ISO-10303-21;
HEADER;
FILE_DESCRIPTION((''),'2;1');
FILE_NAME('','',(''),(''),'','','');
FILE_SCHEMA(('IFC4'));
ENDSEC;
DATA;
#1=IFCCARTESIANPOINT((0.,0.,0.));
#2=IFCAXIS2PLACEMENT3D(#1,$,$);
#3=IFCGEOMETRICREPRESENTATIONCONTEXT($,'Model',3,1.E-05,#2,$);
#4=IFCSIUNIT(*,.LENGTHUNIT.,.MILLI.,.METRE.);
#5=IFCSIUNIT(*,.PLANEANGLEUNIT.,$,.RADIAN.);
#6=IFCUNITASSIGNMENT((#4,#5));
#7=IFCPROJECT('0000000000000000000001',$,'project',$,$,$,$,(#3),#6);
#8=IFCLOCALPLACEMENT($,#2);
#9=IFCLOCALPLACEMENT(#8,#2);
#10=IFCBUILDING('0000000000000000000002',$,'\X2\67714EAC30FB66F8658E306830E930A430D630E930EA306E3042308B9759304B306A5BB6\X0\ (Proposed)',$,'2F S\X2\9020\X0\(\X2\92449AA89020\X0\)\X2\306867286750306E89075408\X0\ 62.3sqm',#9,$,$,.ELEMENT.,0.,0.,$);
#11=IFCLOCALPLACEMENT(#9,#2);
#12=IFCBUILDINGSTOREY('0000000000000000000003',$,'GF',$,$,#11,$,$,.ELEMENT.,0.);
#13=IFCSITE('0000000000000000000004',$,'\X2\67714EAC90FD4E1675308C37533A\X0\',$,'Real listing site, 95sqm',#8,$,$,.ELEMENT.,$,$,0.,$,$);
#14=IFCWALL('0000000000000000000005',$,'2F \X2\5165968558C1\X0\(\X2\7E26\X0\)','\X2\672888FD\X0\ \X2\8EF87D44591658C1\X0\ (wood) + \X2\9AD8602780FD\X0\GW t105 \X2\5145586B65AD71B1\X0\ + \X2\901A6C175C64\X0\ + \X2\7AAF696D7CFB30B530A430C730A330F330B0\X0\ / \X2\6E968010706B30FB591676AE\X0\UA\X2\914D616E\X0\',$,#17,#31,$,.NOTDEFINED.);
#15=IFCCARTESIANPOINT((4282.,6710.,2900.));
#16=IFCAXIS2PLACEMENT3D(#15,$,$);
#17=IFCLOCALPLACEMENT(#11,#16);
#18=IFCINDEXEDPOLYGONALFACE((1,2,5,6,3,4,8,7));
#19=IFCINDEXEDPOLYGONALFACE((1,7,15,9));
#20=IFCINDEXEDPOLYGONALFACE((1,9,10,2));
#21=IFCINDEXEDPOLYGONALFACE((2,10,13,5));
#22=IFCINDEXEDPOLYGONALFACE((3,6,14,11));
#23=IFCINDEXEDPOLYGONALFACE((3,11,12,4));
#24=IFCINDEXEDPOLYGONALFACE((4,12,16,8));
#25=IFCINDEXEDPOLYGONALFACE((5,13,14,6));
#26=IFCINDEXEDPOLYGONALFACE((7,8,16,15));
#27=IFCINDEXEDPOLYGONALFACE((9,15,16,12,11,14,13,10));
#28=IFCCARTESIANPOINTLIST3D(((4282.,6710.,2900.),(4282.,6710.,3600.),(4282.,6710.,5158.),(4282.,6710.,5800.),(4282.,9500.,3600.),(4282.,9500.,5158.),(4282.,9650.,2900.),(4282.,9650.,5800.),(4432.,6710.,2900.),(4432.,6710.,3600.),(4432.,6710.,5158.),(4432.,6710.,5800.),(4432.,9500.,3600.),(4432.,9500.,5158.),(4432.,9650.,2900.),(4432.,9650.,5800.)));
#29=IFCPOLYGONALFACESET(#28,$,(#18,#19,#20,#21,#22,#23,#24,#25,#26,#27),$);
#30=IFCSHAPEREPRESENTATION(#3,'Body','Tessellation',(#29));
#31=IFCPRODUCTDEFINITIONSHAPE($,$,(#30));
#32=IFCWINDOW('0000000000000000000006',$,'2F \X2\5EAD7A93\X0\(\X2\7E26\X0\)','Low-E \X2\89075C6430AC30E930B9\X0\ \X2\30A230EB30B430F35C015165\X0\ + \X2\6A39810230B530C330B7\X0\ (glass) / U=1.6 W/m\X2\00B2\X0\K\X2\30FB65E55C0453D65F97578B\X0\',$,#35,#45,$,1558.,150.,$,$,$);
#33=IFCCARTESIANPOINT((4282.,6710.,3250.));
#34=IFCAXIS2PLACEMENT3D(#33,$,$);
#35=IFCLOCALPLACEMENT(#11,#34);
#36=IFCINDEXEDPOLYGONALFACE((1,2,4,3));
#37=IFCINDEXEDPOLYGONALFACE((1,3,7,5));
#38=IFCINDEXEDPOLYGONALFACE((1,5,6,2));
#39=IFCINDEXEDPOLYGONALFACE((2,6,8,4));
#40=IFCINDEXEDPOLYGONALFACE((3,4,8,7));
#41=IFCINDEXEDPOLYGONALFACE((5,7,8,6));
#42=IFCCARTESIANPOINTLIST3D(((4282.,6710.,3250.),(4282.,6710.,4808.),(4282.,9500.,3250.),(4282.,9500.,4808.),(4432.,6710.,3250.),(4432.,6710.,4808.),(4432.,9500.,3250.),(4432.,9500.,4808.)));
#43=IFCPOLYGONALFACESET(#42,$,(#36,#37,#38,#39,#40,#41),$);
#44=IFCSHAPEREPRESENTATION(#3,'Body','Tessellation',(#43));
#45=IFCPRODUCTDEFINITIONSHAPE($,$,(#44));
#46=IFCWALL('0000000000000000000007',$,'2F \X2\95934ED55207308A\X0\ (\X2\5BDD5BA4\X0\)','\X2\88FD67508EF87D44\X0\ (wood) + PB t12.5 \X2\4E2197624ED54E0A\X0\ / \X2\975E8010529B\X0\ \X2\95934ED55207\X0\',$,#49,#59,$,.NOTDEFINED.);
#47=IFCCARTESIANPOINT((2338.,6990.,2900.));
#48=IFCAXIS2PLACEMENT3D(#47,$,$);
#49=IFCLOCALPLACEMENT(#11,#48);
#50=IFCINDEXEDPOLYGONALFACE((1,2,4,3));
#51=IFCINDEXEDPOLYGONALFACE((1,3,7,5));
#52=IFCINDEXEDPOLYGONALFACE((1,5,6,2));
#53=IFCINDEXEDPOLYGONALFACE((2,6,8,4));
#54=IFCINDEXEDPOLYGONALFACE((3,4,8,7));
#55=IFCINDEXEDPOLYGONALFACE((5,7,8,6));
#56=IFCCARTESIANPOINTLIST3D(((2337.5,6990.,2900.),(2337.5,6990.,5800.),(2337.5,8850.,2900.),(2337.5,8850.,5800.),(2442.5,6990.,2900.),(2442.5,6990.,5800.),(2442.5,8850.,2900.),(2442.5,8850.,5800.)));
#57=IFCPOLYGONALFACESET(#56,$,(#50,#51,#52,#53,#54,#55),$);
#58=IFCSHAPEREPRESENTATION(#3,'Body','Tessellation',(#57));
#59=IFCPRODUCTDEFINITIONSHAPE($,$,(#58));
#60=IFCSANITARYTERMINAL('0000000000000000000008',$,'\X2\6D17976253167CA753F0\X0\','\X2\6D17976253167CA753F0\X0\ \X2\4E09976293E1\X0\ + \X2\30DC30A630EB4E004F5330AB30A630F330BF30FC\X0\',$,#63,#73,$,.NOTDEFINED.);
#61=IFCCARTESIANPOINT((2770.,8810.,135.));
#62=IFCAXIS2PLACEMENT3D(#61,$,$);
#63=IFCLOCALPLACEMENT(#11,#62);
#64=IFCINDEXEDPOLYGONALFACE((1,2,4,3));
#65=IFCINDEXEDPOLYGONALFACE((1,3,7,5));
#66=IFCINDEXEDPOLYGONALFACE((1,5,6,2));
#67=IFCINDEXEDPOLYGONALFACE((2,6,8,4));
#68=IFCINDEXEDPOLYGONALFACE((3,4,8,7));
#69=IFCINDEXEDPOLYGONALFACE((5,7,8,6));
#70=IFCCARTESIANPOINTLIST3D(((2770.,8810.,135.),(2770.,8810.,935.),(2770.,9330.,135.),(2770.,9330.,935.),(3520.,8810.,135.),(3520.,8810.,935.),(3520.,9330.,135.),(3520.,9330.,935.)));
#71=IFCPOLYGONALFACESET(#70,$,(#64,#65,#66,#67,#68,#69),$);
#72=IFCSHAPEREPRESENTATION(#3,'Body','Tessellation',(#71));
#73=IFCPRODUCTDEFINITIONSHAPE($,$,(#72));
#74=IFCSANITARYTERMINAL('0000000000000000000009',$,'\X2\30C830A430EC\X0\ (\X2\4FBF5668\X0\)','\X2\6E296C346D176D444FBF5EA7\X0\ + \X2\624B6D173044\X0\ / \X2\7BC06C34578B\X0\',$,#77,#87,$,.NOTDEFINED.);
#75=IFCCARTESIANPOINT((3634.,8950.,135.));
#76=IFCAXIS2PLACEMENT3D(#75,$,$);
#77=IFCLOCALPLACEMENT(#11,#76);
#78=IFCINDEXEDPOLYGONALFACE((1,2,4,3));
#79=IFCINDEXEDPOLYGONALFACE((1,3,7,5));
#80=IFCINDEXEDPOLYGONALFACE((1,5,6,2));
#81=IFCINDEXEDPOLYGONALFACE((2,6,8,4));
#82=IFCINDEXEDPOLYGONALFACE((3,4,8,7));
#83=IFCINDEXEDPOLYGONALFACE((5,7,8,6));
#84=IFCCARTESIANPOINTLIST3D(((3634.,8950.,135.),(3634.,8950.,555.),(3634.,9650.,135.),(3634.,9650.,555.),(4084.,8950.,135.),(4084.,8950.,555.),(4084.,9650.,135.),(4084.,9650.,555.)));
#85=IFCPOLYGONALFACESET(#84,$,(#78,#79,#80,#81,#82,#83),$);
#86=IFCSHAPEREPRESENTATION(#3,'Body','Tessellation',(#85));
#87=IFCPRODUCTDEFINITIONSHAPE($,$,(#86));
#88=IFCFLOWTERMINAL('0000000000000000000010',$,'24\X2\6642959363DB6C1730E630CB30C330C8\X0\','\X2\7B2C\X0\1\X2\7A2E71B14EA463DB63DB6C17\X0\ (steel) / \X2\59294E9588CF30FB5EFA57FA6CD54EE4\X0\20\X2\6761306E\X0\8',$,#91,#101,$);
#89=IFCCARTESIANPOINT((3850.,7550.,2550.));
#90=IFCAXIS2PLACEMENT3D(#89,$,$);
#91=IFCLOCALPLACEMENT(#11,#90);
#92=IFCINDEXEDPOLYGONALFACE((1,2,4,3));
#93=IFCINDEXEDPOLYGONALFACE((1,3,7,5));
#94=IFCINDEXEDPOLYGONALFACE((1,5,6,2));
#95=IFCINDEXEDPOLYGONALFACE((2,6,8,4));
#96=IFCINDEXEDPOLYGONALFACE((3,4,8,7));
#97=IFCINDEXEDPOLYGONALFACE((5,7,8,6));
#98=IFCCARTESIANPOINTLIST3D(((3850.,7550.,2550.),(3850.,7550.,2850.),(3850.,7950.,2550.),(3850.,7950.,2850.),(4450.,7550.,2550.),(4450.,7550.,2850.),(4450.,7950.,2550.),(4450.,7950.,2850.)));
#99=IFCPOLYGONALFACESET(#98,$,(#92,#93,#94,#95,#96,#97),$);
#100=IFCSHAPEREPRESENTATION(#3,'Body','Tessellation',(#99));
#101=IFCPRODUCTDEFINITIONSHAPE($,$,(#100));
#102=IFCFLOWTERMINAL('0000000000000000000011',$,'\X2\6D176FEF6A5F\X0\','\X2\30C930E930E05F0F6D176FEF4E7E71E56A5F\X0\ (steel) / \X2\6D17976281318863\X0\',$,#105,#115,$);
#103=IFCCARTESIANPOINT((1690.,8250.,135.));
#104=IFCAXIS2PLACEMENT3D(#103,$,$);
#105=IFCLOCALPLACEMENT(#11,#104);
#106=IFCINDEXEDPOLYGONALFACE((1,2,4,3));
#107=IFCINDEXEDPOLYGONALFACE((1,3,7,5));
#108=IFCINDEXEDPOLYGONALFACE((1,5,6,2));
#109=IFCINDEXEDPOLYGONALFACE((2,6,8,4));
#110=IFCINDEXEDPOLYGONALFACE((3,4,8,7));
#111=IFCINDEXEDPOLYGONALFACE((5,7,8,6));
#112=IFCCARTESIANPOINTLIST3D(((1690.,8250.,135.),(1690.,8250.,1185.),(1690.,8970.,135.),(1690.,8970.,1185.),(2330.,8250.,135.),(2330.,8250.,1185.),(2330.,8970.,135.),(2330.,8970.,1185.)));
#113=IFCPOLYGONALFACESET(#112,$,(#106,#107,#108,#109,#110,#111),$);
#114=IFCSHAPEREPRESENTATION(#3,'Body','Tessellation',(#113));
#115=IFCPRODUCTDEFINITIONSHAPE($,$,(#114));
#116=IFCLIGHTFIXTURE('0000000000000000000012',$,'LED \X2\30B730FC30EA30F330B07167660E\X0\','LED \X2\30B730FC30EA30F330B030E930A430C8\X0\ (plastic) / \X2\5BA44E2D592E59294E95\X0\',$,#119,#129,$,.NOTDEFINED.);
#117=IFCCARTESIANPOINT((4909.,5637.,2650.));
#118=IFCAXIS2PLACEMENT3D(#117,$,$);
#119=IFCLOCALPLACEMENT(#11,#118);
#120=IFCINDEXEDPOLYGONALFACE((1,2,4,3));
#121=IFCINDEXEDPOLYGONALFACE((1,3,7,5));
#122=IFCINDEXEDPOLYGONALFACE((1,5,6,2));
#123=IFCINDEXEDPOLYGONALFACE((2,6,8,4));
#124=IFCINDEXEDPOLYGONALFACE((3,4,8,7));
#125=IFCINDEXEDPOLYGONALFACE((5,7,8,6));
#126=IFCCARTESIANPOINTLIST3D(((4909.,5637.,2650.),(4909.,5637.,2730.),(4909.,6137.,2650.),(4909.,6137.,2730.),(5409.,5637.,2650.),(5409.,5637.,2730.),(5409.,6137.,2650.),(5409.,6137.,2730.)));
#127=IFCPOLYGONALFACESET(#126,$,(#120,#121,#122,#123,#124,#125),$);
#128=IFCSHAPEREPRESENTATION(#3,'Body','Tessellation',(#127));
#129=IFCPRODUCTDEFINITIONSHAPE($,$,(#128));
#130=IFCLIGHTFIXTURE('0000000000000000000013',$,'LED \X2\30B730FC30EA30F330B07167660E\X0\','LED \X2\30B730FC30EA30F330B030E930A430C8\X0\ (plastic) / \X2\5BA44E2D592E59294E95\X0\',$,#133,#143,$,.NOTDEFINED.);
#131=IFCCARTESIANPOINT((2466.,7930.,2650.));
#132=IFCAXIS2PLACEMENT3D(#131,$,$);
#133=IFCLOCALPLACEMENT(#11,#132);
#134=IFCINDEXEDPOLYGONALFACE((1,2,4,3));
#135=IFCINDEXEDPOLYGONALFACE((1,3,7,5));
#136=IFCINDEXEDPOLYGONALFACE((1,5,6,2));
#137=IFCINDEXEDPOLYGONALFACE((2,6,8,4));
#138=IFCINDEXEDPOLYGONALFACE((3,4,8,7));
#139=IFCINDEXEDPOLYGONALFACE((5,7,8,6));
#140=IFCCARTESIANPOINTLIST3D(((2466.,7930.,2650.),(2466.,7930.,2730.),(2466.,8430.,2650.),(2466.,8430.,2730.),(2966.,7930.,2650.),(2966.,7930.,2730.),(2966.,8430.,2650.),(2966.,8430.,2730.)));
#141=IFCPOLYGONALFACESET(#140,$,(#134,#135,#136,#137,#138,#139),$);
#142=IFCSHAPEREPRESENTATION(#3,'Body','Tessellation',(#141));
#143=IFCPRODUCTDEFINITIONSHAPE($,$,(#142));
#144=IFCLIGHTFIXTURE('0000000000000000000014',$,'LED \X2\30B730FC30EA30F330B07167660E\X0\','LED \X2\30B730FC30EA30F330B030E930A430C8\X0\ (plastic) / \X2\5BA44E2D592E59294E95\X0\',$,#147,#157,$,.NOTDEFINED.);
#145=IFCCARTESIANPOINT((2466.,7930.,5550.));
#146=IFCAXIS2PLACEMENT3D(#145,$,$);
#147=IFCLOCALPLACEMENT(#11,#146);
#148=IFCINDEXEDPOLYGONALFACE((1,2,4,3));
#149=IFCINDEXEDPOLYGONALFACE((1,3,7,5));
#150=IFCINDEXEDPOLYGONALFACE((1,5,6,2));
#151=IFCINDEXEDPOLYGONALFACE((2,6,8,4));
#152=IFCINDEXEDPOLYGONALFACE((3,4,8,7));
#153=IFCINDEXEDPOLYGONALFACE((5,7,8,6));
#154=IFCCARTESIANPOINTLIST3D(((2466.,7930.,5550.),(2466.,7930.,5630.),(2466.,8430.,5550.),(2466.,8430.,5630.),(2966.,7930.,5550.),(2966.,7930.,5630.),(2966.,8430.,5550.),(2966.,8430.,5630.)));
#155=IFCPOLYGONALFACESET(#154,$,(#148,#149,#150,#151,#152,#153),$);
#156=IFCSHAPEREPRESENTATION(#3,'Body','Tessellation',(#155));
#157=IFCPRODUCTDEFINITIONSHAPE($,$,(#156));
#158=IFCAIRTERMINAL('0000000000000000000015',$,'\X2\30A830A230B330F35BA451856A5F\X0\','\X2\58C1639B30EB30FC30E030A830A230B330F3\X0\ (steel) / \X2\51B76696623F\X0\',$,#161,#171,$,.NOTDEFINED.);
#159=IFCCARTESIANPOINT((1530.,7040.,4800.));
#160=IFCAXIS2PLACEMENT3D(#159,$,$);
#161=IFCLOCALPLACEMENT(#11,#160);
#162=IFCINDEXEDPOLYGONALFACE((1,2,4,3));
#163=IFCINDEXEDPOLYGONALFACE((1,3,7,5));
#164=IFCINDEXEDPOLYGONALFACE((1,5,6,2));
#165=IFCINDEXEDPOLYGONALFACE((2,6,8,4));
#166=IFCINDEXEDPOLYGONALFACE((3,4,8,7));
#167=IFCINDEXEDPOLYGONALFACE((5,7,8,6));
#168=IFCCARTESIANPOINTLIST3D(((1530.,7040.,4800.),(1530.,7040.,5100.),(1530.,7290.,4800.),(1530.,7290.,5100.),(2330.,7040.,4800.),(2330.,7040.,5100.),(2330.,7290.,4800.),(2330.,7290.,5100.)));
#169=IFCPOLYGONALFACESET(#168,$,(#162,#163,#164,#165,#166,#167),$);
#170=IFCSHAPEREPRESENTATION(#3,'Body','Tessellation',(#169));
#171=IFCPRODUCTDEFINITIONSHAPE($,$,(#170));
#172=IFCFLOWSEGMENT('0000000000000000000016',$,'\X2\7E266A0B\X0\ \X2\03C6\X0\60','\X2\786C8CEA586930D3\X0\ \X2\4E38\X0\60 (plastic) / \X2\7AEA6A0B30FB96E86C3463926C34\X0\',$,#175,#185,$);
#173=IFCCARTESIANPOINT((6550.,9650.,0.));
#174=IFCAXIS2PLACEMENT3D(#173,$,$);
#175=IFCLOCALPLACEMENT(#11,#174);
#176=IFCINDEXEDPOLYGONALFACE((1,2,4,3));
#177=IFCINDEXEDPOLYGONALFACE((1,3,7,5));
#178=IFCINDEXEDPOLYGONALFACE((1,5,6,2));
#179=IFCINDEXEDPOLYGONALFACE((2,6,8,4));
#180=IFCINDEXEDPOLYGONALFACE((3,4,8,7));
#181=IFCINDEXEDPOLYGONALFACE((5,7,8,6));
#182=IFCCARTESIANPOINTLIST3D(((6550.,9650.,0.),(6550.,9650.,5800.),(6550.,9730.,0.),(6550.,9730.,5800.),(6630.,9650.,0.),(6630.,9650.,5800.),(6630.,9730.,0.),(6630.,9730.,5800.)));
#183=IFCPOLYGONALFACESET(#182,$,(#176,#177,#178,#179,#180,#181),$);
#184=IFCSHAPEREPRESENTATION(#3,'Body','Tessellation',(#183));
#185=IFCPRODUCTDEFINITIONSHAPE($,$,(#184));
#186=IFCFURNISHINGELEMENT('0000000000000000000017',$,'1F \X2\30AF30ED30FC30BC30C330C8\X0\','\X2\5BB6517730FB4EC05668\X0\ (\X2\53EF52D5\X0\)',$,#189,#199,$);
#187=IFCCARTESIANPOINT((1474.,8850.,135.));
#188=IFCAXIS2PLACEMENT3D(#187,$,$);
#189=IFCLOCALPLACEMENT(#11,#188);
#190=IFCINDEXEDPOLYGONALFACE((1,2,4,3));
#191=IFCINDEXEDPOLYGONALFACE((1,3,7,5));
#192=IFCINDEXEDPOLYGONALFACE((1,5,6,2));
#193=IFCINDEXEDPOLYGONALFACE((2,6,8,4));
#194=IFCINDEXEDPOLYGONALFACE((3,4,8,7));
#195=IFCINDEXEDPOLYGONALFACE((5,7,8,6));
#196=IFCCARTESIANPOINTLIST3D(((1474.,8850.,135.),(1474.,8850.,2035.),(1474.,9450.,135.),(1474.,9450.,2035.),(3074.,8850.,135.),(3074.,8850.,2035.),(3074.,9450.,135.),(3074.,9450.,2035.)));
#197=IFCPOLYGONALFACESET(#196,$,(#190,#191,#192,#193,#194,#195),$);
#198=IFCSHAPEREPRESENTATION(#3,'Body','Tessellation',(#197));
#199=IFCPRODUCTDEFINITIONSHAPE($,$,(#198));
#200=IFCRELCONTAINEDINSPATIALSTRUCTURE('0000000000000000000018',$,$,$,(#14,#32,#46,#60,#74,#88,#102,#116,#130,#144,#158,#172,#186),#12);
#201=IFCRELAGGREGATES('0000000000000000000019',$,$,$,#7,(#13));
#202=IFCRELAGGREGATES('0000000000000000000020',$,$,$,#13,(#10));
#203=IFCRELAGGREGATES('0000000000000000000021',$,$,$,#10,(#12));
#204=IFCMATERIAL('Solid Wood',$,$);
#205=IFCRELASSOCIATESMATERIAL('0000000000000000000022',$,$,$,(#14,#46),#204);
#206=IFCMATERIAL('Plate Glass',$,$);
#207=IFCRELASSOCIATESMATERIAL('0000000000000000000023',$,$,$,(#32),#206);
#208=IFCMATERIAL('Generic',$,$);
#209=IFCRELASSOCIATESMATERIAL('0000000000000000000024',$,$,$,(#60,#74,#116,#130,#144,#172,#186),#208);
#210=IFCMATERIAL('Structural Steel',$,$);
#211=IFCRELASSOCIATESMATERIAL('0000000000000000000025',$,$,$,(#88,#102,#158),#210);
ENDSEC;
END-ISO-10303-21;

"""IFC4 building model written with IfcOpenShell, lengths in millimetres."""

from ifc_helpers import new_model, si_unit, frame, frame_2d, origin, place, context, project, spatial, rectangle, extrude, material, element, fill, save


model = new_model("IFC4")

# Units and contexts
model_context = context("Model", 3, precision=1e-05, world=origin())
ifc_project = project(units=[si_unit("LENGTHUNIT", "METRE", prefix="MILLI"), si_unit("PLANEANGLEUNIT", "RADIAN")], contexts=[model_context])

# Site, building, storey
site_placement = place(None, origin())
site = spatial("IfcSite", under=ifc_project, at=site_placement, Name="東京都世田谷区", ObjectType="Real listing site, 95sqm", CompositionType="ELEMENT", RefElevation=0.0)
building_placement = place(site_placement, origin())
building = spatial("IfcBuilding", under=site, at=building_placement, Name="東京・書斎とライブラリのある静かな家 (Proposed)", ObjectType="2F S造(鉄骨造)と木材の複合 62.3sqm", CompositionType="ELEMENT", ElevationOfRefHeight=0.0, ElevationOfTerrain=0.0)
storey_placement = place(building_placement, origin())
storey = spatial("IfcBuildingStorey", under=building, at=storey_placement, Name="GF", CompositionType="ELEMENT", Elevation=0.0)

# Shared definitions
ifc_material_1 = material(Name="Solid Wood")

# Shared definitions
ifc_material_2 = material(Name="Plate Glass")

# Wall, opening, window
wall_1_placement = place(storey_placement, frame((4282.0, 6710.0, 2900.0)))
wall_1 = element("IfcWall", 1, at=wall_1_placement, inside=storey, material=ifc_material_1, Name="2F 入隅壁(縦)", Description="木製 軸組外壁 (wood) + 高性能GW t105 充填断熱 + 通気層 + 窯業系サイディング / 準耐火・外皮UA配慮", PredefinedType="NOTDEFINED", context=model_context, shape_type="SweptSolid", body=[
    extrude(rectangle(XDim=150.0, YDim=2940.0, at=frame_2d((75.0, 1470.0))), frame((4282.0, 6710.0, 2900.0)), (0.0, 0.0, 1.0), 2900.0),
])
opening_1_placement = place(storey_placement, frame((4282.0, 6710.0, 3250.0)))
opening_1 = element("IfcOpeningElement", 2, at=opening_1_placement, cuts=wall_1, PredefinedType="NOTDEFINED", context=model_context, shape_type="SweptSolid", body=[
    extrude(rectangle(XDim=150.0, YDim=2790.0, at=frame_2d((75.0, 1395.0))), frame((4282.0, 6710.0, 3250.0)), (0.0, 0.0, 1.0), 1558.0),
])
window_1_placement = place(storey_placement, frame((4282.0, 6710.0, 3250.0)))
window_1 = element("IfcWindow", 3, at=window_1_placement, inside=storey, material=ifc_material_2, Name="2F 庭窓(縦)", Description="Low-E 複層ガラス アルゴン封入 + 樹脂サッシ (glass) / U=1.6 W/m²K・日射取得型", OverallHeight=1558.0, OverallWidth=150.0, context=model_context, shape_type="SweptSolid", body=[
    extrude(rectangle(XDim=150.0, YDim=2790.0, at=frame_2d((75.0, 1395.0))), frame((4282.0, 6710.0, 3250.0)), (0.0, 0.0, 1.0), 1558.0),
])
fill(opening_1, window_1)

# Wall
wall_2_placement = place(storey_placement, frame((2338.0, 6990.0, 2900.0)))
element("IfcWall", 4, at=wall_2_placement, inside=storey, material=ifc_material_1, Name="2F 間仕切り (寝室)", Description="製材軸組 (wood) + PB t12.5 両面仕上 / 非耐力 間仕切", PredefinedType="NOTDEFINED", context=model_context, shape_type="SweptSolid", body=[
    extrude(rectangle(XDim=105.0, YDim=1860.0, at=frame_2d((52.0, 930.0))), frame((2338.0, 6990.0, 2900.0)), (0.0, 0.0, 1.0), 2900.0),
])

# Sanitary terminals
ifc_material_3 = material(Name="Generic")
sanitary_terminal_1_placement = place(storey_placement, frame((2770.0, 8810.0, 135.0)))
element("IfcSanitaryTerminal", 5, at=sanitary_terminal_1_placement, inside=storey, material=ifc_material_3, Name="洗面化粧台", Description="洗面化粧台 三面鏡 + ボウル一体カウンター", PredefinedType="NOTDEFINED", context=model_context, shape_type="SweptSolid", body=[
    extrude(rectangle(XDim=750.0, YDim=520.0, at=frame_2d((375.0, 260.0))), frame((2770.0, 8810.0, 135.0)), (0.0, 0.0, 1.0), 800.0),
])
sanitary_terminal_2_placement = place(storey_placement, frame((3634.0, 8950.0, 135.0)))
element("IfcSanitaryTerminal", 6, at=sanitary_terminal_2_placement, inside=storey, material=ifc_material_3, Name="トイレ (便器)", Description="温水洗浄便座 + 手洗い / 節水型", PredefinedType="NOTDEFINED", context=model_context, shape_type="SweptSolid", body=[
    extrude(rectangle(XDim=450.0, YDim=700.0, at=frame_2d((225.0, 350.0))), frame((3634.0, 8950.0, 135.0)), (0.0, 0.0, 1.0), 420.0),
])

# Flow terminals
ifc_material_4 = material(Name="Structural Steel")
flow_terminal_1_placement = place(storey_placement, frame((3850.0, 7550.0, 2550.0)))
element("IfcFlowTerminal", 7, at=flow_terminal_1_placement, inside=storey, material=ifc_material_4, Name="24時間換気ユニット", Description="第1種熱交換換気 (steel) / 天井裏・建基法令20条の8", context=model_context, shape_type="SweptSolid", body=[
    extrude(rectangle(XDim=600.0, YDim=400.0, at=frame_2d((300.0, 200.0))), frame((3850.0, 7550.0, 2550.0)), (0.0, 0.0, 1.0), 300.0),
])
flow_terminal_2_placement = place(storey_placement, frame((1690.0, 8250.0, 135.0)))
element("IfcFlowTerminal", 8, at=flow_terminal_2_placement, inside=storey, material=ifc_material_4, Name="洗濯機", Description="ドラム式洗濯乾燥機 (steel) / 洗面脱衣", context=model_context, shape_type="SweptSolid", body=[
    extrude(rectangle(XDim=640.0, YDim=720.0, at=frame_2d((320.0, 360.0))), frame((1690.0, 8250.0, 135.0)), (0.0, 0.0, 1.0), 1050.0),
])

# Light fixtures
light_fixture_1_placement = place(storey_placement, frame((4909.0, 5637.0, 2650.0)))
element("IfcLightFixture", 9, at=light_fixture_1_placement, inside=storey, material=ifc_material_3, Name="LED シーリング照明", Description="LED シーリングライト (plastic) / 室中央天井", PredefinedType="NOTDEFINED", context=model_context, shape_type="SweptSolid", body=[
    extrude(rectangle(XDim=500.0, YDim=500.0, at=frame_2d((250.0, 250.0))), frame((4909.0, 5637.0, 2650.0)), (0.0, 0.0, 1.0), 80.0),
])
light_fixture_2_placement = place(storey_placement, frame((2466.0, 7930.0, 2650.0)))
element("IfcLightFixture", 10, at=light_fixture_2_placement, inside=storey, material=ifc_material_3, Name="LED シーリング照明", Description="LED シーリングライト (plastic) / 室中央天井", PredefinedType="NOTDEFINED", context=model_context, shape_type="SweptSolid", body=[
    extrude(rectangle(XDim=500.0, YDim=500.0, at=frame_2d((250.0, 250.0))), frame((2466.0, 7930.0, 2650.0)), (0.0, 0.0, 1.0), 80.0),
])
light_fixture_3_placement = place(storey_placement, frame((2466.0, 7930.0, 5550.0)))
element("IfcLightFixture", 11, at=light_fixture_3_placement, inside=storey, material=ifc_material_3, Name="LED シーリング照明", Description="LED シーリングライト (plastic) / 室中央天井", PredefinedType="NOTDEFINED", context=model_context, shape_type="SweptSolid", body=[
    extrude(rectangle(XDim=500.0, YDim=500.0, at=frame_2d((250.0, 250.0))), frame((2466.0, 7930.0, 5550.0)), (0.0, 0.0, 1.0), 80.0),
])

# Air terminal
air_terminal_placement = place(storey_placement, frame((1530.0, 7040.0, 4800.0)))
element("IfcAirTerminal", 12, at=air_terminal_placement, inside=storey, material=ifc_material_4, Name="エアコン室内機", Description="壁掛ルームエアコン (steel) / 冷暖房", PredefinedType="NOTDEFINED", context=model_context, shape_type="SweptSolid", body=[
    extrude(rectangle(XDim=800.0, YDim=250.0, at=frame_2d((400.0, 125.0))), frame((1530.0, 7040.0, 4800.0)), (0.0, 0.0, 1.0), 300.0),
])

# Flow segment
flow_segment_placement = place(storey_placement, frame((6550.0, 9650.0, 0.0)))
element("IfcFlowSegment", 13, at=flow_segment_placement, inside=storey, material=ifc_material_3, Name="縦樋 φ60", Description="硬質塩ビ 丸60 (plastic) / 竪樋・雨水排水", context=model_context, shape_type="SweptSolid", body=[
    extrude(rectangle(XDim=80.0, YDim=80.0, at=frame_2d((40.0, 40.0))), frame((6550.0, 9650.0, 0.0)), (0.0, 0.0, 1.0), 5800.0),
])

# Furnishing element
furnishing_1_placement = place(storey_placement, frame((1474.0, 8850.0, 135.0)))
element("IfcFurnishingElement", 14, at=furnishing_1_placement, inside=storey, material=ifc_material_3, Name="1F クローゼット", Description="家具・什器 (可動)", context=model_context, shape_type="SweptSolid", body=[
    extrude(rectangle(XDim=1600.0, YDim=600.0, at=frame_2d((800.0, 300.0))), frame((1474.0, 8850.0, 135.0)), (0.0, 0.0, 1.0), 1900.0),
])

save(model, "model.ifc")
